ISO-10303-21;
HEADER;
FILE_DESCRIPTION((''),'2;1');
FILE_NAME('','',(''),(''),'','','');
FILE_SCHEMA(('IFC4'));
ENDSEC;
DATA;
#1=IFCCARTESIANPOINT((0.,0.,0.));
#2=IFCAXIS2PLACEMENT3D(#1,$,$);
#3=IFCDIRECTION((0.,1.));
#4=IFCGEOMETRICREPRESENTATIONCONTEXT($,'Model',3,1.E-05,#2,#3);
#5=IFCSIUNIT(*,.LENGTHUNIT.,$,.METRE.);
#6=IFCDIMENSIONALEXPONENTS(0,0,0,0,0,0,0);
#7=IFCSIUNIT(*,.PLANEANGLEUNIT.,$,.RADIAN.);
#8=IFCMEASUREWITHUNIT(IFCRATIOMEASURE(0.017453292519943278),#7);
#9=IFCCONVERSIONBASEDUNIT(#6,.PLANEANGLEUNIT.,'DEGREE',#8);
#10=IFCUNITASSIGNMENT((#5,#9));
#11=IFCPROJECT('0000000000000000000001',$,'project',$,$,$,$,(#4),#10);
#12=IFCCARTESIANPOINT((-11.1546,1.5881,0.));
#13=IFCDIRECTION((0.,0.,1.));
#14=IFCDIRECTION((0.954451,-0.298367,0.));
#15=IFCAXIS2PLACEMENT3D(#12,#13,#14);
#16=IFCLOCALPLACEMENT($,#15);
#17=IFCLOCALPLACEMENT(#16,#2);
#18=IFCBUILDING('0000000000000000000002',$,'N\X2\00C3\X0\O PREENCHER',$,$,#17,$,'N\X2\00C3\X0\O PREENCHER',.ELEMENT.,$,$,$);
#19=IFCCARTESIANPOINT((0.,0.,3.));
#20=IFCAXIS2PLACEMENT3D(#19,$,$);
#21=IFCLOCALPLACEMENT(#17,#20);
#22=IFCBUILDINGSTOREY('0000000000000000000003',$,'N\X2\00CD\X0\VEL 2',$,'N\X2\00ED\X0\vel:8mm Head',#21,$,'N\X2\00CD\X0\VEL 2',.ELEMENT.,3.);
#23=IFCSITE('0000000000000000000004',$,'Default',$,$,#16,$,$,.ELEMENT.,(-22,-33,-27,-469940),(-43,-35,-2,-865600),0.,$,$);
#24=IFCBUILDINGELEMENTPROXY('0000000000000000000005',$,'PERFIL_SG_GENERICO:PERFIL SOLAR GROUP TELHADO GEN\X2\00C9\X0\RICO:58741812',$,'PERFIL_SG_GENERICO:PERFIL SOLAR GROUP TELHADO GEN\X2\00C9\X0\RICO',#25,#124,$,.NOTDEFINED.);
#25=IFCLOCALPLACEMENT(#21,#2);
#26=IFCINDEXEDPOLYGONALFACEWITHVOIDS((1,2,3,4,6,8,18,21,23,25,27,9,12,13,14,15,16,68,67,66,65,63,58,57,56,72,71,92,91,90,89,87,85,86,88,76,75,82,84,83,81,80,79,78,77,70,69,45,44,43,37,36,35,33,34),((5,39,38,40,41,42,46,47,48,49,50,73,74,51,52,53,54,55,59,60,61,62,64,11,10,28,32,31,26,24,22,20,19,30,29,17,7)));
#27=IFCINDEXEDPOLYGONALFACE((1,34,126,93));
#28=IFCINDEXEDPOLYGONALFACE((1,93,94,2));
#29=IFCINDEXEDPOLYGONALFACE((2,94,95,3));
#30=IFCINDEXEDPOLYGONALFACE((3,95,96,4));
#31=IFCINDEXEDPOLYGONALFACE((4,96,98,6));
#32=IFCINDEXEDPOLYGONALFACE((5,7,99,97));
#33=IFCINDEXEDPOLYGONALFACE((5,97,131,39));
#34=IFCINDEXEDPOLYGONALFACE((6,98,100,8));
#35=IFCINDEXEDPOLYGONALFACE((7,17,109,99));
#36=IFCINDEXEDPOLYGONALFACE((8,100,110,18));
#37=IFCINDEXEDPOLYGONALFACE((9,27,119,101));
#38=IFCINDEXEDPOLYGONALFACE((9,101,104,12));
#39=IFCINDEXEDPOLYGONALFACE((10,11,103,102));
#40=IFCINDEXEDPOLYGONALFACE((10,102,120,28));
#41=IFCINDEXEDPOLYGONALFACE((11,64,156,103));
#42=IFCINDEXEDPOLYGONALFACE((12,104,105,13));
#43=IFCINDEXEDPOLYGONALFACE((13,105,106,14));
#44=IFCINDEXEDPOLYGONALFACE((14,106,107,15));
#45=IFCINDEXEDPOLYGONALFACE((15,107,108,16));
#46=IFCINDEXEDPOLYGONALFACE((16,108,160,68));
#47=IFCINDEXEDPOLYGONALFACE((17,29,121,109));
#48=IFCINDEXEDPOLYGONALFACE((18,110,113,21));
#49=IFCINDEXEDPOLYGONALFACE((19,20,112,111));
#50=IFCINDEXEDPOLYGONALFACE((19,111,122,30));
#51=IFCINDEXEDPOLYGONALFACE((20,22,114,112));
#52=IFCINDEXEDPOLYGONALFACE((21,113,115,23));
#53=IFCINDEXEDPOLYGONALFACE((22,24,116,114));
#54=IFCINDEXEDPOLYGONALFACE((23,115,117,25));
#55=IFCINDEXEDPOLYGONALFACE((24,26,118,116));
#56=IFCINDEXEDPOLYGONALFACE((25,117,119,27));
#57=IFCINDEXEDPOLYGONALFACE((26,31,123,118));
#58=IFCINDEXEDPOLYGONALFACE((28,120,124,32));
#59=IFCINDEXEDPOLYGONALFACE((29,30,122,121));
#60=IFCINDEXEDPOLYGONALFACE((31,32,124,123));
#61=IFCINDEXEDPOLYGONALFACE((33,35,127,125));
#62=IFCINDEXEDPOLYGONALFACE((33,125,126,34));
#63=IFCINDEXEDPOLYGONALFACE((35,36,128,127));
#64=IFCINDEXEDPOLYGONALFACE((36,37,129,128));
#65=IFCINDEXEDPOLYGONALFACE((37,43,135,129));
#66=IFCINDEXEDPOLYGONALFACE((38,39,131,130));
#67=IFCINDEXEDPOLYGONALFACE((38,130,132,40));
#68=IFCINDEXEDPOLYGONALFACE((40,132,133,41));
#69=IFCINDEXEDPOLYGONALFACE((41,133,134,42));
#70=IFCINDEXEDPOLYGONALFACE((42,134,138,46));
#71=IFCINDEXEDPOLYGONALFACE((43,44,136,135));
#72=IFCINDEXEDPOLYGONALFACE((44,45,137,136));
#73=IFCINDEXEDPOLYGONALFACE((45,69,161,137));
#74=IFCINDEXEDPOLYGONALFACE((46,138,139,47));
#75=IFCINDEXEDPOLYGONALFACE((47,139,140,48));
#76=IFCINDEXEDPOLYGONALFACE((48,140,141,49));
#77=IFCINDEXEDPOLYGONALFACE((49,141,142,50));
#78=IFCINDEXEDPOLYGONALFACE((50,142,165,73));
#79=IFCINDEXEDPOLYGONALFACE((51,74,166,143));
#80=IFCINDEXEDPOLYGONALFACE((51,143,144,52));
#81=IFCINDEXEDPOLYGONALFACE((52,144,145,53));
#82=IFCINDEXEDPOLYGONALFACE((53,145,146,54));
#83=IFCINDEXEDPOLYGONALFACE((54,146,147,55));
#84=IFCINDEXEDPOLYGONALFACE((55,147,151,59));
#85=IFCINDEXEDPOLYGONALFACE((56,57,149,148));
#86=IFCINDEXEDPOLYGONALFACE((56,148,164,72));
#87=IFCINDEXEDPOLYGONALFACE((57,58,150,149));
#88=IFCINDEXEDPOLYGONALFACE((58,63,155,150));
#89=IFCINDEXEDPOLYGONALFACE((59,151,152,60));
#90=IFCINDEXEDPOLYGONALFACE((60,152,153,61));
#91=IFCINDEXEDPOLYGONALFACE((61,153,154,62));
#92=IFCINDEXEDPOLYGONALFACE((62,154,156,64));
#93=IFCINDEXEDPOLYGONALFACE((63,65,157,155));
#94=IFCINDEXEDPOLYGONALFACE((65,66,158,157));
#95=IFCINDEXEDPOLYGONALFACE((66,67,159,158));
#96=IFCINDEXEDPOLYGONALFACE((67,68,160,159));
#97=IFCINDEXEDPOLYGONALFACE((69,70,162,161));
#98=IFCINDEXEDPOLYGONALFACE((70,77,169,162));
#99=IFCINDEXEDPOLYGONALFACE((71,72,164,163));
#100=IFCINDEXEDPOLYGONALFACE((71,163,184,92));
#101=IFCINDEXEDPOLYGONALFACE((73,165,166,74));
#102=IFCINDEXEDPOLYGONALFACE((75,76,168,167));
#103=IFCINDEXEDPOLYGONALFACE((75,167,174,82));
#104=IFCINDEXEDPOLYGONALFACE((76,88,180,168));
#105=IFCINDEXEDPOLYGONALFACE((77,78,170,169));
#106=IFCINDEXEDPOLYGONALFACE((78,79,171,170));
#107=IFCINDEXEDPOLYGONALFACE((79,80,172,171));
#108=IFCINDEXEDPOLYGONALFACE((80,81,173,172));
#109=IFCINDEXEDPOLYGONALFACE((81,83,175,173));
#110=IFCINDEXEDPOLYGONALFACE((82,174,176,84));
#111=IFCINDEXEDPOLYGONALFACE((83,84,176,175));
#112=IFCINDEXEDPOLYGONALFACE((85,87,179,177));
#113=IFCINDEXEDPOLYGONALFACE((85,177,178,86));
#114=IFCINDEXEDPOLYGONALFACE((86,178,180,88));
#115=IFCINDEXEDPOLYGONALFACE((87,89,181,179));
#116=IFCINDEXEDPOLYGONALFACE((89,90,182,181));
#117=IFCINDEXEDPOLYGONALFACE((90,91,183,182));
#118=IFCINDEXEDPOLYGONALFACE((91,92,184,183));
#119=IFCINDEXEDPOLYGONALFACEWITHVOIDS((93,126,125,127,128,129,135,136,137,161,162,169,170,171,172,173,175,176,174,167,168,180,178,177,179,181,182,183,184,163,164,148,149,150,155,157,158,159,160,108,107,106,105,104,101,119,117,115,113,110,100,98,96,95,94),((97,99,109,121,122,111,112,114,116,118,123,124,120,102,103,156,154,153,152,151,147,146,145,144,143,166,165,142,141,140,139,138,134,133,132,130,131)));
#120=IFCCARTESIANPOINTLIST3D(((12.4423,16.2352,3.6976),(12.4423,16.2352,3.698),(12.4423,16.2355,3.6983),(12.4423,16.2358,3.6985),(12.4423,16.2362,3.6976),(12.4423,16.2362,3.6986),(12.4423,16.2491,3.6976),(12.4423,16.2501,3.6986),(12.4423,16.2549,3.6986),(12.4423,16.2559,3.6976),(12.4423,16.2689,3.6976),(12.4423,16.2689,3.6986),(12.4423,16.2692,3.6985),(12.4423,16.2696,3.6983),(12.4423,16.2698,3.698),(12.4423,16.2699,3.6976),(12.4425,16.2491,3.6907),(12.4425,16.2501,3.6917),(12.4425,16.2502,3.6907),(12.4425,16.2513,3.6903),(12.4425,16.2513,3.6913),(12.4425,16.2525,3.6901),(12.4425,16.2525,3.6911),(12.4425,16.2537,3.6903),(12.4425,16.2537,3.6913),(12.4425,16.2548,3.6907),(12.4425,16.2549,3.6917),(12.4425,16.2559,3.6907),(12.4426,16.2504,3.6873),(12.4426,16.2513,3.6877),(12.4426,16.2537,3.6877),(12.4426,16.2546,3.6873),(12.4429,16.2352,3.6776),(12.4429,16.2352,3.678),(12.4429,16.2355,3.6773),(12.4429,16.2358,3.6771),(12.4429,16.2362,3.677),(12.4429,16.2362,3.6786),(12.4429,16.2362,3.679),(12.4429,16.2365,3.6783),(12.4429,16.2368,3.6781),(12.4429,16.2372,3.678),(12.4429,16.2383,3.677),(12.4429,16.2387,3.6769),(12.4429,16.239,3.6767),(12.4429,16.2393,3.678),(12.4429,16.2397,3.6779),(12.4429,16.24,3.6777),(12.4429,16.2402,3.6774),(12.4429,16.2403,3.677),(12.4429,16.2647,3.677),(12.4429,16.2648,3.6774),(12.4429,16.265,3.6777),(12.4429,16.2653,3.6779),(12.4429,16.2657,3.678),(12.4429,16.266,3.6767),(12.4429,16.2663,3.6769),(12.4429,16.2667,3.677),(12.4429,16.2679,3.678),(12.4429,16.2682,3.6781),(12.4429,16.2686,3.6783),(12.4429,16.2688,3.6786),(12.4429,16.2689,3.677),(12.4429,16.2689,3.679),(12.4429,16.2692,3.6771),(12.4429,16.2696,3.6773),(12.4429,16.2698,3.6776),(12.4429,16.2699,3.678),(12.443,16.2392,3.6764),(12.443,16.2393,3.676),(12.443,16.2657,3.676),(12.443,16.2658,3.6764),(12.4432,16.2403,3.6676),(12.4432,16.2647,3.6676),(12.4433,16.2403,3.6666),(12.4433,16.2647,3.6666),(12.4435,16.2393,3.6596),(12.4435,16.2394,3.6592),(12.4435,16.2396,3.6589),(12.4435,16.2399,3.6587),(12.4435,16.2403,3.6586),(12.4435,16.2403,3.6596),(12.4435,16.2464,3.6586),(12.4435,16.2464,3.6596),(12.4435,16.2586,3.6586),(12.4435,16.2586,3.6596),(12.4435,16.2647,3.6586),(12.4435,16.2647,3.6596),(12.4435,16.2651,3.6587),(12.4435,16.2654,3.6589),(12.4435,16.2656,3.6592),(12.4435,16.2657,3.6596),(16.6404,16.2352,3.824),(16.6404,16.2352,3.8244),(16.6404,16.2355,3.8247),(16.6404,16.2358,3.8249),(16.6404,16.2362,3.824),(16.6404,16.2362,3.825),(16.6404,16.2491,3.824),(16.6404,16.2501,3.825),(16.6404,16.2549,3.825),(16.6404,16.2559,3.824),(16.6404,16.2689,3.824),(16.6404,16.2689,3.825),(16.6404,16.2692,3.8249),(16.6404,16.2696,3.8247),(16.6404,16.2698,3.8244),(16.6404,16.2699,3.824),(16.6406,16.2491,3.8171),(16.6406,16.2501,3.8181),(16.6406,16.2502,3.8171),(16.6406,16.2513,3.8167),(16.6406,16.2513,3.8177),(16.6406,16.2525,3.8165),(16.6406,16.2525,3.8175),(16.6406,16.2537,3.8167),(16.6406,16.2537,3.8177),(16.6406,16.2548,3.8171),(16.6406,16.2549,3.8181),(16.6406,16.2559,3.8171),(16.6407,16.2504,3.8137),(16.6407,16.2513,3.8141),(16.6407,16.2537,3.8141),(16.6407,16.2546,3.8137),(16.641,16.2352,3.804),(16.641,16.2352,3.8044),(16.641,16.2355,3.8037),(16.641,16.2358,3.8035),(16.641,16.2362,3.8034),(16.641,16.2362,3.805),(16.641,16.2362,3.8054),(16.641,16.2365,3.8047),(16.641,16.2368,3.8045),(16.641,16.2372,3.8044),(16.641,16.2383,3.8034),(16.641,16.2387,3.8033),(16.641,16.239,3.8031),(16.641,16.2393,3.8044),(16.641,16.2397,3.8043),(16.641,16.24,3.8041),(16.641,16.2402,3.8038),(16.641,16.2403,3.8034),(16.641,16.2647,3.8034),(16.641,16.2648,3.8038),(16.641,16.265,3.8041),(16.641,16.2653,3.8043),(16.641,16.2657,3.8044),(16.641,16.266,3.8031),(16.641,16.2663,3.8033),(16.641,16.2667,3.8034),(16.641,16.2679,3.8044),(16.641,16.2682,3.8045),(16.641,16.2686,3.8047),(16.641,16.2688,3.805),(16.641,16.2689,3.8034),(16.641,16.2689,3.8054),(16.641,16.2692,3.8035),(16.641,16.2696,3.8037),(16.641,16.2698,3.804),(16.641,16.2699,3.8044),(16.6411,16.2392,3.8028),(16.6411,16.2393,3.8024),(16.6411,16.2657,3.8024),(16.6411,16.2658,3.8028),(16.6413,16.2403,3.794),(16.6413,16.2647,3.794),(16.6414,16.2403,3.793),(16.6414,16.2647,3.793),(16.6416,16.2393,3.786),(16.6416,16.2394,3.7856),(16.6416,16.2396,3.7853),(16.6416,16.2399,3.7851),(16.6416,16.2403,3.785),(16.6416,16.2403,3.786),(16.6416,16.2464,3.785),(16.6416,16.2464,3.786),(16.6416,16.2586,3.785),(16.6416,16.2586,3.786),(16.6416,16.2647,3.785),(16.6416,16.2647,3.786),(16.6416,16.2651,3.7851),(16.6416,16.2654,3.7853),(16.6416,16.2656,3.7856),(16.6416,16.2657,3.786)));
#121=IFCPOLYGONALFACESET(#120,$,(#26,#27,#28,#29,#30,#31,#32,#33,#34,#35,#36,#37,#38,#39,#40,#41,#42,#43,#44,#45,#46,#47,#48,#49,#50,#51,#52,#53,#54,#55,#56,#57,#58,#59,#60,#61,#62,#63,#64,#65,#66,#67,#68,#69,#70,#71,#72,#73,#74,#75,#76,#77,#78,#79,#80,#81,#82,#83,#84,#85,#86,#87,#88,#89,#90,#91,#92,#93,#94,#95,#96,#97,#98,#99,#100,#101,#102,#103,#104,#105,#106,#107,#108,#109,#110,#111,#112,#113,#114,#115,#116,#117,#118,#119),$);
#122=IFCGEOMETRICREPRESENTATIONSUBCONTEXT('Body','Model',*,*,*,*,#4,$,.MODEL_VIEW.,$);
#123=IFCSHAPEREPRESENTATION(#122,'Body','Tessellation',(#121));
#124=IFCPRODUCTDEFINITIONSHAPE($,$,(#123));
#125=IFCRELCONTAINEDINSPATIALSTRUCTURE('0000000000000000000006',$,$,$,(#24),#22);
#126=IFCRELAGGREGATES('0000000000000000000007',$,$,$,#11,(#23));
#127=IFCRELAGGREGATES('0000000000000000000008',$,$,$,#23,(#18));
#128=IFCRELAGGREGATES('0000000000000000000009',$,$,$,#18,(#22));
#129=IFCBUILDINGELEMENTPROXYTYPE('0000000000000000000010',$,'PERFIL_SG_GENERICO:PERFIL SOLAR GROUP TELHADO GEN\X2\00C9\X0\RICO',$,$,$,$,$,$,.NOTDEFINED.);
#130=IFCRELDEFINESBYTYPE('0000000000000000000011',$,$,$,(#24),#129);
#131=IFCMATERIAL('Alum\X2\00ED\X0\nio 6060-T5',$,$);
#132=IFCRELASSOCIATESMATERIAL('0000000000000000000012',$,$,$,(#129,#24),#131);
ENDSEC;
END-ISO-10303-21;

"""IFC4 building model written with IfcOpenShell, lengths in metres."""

from ifc_helpers import new_model, entity, si_unit, converted_unit, direction, frame, origin, place, context, subcontext, project, spatial, line, arc, indexed_curve, outline, extrude, source, transform, mapped, material, type_object, type_shapes, element, save


model = new_model("IFC4")

# Units and contexts
model_context = context("Model", 3, precision=1e-05, world=origin(), true_north=direction((0.0, 1.0)))
body_context = subcontext(model_context, "Body", "Model", "MODEL_VIEW")
ifc_project = project(units=[si_unit("LENGTHUNIT", "METRE"), converted_unit("PLANEANGLEUNIT", "DEGREE", entity("IfcRatioMeasure", 0.017453292519943278), si_unit("PLANEANGLEUNIT", "RADIAN"), dimensions=[0, 0, 0, 0, 0, 0, 0])], contexts=[model_context])

# Site, building, storey
site_placement = place(None, frame((-11.1546, 1.5881, 0.0), z_axis=(0.0, 0.0, 1.0), x_axis=(0.954451, -0.298367, 0.0)))
site = spatial("IfcSite", under=ifc_project, at=site_placement, Name="Default", CompositionType="ELEMENT", RefLatitude=(-22, -33, -27, -469940), RefLongitude=(-43, -35, -2, -865600), RefElevation=0.0)
building_placement = place(site_placement, origin())
building = spatial("IfcBuilding", under=site, at=building_placement, Name="NÃO PREENCHER", LongName="NÃO PREENCHER", CompositionType="ELEMENT")
storey_placement = place(building_placement, frame((0.0, 0.0, 3.0)))
storey = spatial("IfcBuildingStorey", under=building, at=storey_placement, Name="NÍVEL 2", ObjectType="Nível:8mm Head", LongName="NÍVEL 2", CompositionType="ELEMENT", Elevation=3.0)

# Building element proxy
ifc_material_1 = material(Name="Alumínio 6060-T5")
building_element_proxy_type_1 = type_object("IfcBuildingElementProxyType", Name="PERFIL_SG_GENERICO:PERFIL SOLAR GROUP TELHADO GENÉRICO", PredefinedType="NOTDEFINED", material=ifc_material_1)
shared_shape_1 = source(origin(), body_context, "Body", "SweptSolid", [
    extrude(outline(indexed_curve([(-0.0122, -0.0169), (-0.0061, -0.0169), (-0.0061, -0.0159), (-0.0122, -0.0159), (-0.0122, -0.0089), (0.0122, -0.0089), (0.0122, -0.0159), (0.0061, -0.0159), (0.0061, -0.0169), (0.0122, -0.0169), (0.0129, -0.0166), (0.0132, -0.0159), (0.0132, 0.0005), (0.0135, 0.0012), (0.0142, 0.0015), (0.0164, 0.0015), (0.0171, 0.0018), (0.0174, 0.0025), (0.0174, 0.0221), (0.0171, 0.0228), (0.0164, 0.0231), (0.0024, 0.0231), (0.0024, 0.0162), (0.0, 0.0156), (-0.0024, 0.0162), (-0.0024, 0.0231), (-0.0164, 0.0231), (-0.0171, 0.0228), (-0.0174, 0.0221), (-0.0174, 0.0025), (-0.0171, 0.0018), (-0.0164, 0.0015), (-0.0142, 0.0015), (-0.0135, 0.0012), (-0.0132, 0.0005), (-0.0132, -0.0159), (-0.0129, -0.0166)], segments=[line(1, 2, 3, 4, 5, 6, 7, 8, 9, 10), arc(10, 11, 12), line(12, 13), arc(13, 14, 15), line(15, 16), arc(16, 17, 18), line(18, 19), arc(19, 20, 21), line(21, 22, 23), arc(23, 24, 25), line(25, 26, 27), arc(27, 28, 29), line(29, 30), arc(30, 31, 32), line(32, 33), arc(33, 34, 35), line(35, 36), arc(36, 37, 1)], self_intersect=False), holes=[indexed_curve([(-0.0122, -0.0079), (-0.0122, 0.0015), (-0.0125, 0.0022), (-0.0132, 0.0025), (-0.0154, 0.0025), (-0.0161, 0.0028), (-0.0164, 0.0035), (-0.0164, 0.0221), (-0.0034, 0.0221), (-0.0034, 0.0152), (-0.0021, 0.0118), (-0.0012, 0.0122), (-0.0023, 0.0151), (0.0, 0.0146), (0.0023, 0.0151), (0.0012, 0.0122), (0.0021, 0.0118), (0.0034, 0.0152), (0.0034, 0.0221), (0.0164, 0.0221), (0.0164, 0.0035), (0.0161, 0.0028), (0.0154, 0.0025), (0.0132, 0.0025), (0.0125, 0.0022), (0.0122, 0.0015), (0.0122, -0.0079)], segments=[line(1, 2), arc(2, 3, 4), line(4, 5), arc(5, 6, 7), line(7, 8, 9, 10, 11, 12, 13), arc(13, 14, 15), line(15, 16, 17, 18, 19, 20, 21), arc(21, 22, 23), line(23, 24), arc(24, 25, 26), line(26, 27, 1)], self_intersect=False)]), frame((0.0, 0.0, 0.0169), z_axis=(1.0, 0.0, 0.0), x_axis=(0.0, 1.0, 0.0)), (0.0, 0.0, 1.0), 4.2),
])
type_shapes(building_element_proxy_type_1, [shared_shape_1])
for number, where, z_axis, x_axis, name in (
    (1, (12.4435, 16.2525, 3.6586), (-0.030095, 0.0, 0.999547), (0.999547, 0.0, 0.030095), "PERFIL_SG_GENERICO:PERFIL SOLAR GROUP TELHADO GENÉRICO:58741812"),
):
    element("IfcBuildingElementProxy", number, at=place(storey_placement, frame(where, z_axis=z_axis, x_axis=x_axis)), inside=storey, type_object=building_element_proxy_type_1, material=ifc_material_1, Name=name, ObjectType="PERFIL_SG_GENERICO:PERFIL SOLAR GROUP TELHADO GENÉRICO", PredefinedType="NOTDEFINED", context=body_context, shape_type="MappedRepresentation", body=[
        mapped(shared_shape_1, transform((0.0, 0.0, 0.0), scale=1.0)),
    ])

save(model, "model.ifc")
